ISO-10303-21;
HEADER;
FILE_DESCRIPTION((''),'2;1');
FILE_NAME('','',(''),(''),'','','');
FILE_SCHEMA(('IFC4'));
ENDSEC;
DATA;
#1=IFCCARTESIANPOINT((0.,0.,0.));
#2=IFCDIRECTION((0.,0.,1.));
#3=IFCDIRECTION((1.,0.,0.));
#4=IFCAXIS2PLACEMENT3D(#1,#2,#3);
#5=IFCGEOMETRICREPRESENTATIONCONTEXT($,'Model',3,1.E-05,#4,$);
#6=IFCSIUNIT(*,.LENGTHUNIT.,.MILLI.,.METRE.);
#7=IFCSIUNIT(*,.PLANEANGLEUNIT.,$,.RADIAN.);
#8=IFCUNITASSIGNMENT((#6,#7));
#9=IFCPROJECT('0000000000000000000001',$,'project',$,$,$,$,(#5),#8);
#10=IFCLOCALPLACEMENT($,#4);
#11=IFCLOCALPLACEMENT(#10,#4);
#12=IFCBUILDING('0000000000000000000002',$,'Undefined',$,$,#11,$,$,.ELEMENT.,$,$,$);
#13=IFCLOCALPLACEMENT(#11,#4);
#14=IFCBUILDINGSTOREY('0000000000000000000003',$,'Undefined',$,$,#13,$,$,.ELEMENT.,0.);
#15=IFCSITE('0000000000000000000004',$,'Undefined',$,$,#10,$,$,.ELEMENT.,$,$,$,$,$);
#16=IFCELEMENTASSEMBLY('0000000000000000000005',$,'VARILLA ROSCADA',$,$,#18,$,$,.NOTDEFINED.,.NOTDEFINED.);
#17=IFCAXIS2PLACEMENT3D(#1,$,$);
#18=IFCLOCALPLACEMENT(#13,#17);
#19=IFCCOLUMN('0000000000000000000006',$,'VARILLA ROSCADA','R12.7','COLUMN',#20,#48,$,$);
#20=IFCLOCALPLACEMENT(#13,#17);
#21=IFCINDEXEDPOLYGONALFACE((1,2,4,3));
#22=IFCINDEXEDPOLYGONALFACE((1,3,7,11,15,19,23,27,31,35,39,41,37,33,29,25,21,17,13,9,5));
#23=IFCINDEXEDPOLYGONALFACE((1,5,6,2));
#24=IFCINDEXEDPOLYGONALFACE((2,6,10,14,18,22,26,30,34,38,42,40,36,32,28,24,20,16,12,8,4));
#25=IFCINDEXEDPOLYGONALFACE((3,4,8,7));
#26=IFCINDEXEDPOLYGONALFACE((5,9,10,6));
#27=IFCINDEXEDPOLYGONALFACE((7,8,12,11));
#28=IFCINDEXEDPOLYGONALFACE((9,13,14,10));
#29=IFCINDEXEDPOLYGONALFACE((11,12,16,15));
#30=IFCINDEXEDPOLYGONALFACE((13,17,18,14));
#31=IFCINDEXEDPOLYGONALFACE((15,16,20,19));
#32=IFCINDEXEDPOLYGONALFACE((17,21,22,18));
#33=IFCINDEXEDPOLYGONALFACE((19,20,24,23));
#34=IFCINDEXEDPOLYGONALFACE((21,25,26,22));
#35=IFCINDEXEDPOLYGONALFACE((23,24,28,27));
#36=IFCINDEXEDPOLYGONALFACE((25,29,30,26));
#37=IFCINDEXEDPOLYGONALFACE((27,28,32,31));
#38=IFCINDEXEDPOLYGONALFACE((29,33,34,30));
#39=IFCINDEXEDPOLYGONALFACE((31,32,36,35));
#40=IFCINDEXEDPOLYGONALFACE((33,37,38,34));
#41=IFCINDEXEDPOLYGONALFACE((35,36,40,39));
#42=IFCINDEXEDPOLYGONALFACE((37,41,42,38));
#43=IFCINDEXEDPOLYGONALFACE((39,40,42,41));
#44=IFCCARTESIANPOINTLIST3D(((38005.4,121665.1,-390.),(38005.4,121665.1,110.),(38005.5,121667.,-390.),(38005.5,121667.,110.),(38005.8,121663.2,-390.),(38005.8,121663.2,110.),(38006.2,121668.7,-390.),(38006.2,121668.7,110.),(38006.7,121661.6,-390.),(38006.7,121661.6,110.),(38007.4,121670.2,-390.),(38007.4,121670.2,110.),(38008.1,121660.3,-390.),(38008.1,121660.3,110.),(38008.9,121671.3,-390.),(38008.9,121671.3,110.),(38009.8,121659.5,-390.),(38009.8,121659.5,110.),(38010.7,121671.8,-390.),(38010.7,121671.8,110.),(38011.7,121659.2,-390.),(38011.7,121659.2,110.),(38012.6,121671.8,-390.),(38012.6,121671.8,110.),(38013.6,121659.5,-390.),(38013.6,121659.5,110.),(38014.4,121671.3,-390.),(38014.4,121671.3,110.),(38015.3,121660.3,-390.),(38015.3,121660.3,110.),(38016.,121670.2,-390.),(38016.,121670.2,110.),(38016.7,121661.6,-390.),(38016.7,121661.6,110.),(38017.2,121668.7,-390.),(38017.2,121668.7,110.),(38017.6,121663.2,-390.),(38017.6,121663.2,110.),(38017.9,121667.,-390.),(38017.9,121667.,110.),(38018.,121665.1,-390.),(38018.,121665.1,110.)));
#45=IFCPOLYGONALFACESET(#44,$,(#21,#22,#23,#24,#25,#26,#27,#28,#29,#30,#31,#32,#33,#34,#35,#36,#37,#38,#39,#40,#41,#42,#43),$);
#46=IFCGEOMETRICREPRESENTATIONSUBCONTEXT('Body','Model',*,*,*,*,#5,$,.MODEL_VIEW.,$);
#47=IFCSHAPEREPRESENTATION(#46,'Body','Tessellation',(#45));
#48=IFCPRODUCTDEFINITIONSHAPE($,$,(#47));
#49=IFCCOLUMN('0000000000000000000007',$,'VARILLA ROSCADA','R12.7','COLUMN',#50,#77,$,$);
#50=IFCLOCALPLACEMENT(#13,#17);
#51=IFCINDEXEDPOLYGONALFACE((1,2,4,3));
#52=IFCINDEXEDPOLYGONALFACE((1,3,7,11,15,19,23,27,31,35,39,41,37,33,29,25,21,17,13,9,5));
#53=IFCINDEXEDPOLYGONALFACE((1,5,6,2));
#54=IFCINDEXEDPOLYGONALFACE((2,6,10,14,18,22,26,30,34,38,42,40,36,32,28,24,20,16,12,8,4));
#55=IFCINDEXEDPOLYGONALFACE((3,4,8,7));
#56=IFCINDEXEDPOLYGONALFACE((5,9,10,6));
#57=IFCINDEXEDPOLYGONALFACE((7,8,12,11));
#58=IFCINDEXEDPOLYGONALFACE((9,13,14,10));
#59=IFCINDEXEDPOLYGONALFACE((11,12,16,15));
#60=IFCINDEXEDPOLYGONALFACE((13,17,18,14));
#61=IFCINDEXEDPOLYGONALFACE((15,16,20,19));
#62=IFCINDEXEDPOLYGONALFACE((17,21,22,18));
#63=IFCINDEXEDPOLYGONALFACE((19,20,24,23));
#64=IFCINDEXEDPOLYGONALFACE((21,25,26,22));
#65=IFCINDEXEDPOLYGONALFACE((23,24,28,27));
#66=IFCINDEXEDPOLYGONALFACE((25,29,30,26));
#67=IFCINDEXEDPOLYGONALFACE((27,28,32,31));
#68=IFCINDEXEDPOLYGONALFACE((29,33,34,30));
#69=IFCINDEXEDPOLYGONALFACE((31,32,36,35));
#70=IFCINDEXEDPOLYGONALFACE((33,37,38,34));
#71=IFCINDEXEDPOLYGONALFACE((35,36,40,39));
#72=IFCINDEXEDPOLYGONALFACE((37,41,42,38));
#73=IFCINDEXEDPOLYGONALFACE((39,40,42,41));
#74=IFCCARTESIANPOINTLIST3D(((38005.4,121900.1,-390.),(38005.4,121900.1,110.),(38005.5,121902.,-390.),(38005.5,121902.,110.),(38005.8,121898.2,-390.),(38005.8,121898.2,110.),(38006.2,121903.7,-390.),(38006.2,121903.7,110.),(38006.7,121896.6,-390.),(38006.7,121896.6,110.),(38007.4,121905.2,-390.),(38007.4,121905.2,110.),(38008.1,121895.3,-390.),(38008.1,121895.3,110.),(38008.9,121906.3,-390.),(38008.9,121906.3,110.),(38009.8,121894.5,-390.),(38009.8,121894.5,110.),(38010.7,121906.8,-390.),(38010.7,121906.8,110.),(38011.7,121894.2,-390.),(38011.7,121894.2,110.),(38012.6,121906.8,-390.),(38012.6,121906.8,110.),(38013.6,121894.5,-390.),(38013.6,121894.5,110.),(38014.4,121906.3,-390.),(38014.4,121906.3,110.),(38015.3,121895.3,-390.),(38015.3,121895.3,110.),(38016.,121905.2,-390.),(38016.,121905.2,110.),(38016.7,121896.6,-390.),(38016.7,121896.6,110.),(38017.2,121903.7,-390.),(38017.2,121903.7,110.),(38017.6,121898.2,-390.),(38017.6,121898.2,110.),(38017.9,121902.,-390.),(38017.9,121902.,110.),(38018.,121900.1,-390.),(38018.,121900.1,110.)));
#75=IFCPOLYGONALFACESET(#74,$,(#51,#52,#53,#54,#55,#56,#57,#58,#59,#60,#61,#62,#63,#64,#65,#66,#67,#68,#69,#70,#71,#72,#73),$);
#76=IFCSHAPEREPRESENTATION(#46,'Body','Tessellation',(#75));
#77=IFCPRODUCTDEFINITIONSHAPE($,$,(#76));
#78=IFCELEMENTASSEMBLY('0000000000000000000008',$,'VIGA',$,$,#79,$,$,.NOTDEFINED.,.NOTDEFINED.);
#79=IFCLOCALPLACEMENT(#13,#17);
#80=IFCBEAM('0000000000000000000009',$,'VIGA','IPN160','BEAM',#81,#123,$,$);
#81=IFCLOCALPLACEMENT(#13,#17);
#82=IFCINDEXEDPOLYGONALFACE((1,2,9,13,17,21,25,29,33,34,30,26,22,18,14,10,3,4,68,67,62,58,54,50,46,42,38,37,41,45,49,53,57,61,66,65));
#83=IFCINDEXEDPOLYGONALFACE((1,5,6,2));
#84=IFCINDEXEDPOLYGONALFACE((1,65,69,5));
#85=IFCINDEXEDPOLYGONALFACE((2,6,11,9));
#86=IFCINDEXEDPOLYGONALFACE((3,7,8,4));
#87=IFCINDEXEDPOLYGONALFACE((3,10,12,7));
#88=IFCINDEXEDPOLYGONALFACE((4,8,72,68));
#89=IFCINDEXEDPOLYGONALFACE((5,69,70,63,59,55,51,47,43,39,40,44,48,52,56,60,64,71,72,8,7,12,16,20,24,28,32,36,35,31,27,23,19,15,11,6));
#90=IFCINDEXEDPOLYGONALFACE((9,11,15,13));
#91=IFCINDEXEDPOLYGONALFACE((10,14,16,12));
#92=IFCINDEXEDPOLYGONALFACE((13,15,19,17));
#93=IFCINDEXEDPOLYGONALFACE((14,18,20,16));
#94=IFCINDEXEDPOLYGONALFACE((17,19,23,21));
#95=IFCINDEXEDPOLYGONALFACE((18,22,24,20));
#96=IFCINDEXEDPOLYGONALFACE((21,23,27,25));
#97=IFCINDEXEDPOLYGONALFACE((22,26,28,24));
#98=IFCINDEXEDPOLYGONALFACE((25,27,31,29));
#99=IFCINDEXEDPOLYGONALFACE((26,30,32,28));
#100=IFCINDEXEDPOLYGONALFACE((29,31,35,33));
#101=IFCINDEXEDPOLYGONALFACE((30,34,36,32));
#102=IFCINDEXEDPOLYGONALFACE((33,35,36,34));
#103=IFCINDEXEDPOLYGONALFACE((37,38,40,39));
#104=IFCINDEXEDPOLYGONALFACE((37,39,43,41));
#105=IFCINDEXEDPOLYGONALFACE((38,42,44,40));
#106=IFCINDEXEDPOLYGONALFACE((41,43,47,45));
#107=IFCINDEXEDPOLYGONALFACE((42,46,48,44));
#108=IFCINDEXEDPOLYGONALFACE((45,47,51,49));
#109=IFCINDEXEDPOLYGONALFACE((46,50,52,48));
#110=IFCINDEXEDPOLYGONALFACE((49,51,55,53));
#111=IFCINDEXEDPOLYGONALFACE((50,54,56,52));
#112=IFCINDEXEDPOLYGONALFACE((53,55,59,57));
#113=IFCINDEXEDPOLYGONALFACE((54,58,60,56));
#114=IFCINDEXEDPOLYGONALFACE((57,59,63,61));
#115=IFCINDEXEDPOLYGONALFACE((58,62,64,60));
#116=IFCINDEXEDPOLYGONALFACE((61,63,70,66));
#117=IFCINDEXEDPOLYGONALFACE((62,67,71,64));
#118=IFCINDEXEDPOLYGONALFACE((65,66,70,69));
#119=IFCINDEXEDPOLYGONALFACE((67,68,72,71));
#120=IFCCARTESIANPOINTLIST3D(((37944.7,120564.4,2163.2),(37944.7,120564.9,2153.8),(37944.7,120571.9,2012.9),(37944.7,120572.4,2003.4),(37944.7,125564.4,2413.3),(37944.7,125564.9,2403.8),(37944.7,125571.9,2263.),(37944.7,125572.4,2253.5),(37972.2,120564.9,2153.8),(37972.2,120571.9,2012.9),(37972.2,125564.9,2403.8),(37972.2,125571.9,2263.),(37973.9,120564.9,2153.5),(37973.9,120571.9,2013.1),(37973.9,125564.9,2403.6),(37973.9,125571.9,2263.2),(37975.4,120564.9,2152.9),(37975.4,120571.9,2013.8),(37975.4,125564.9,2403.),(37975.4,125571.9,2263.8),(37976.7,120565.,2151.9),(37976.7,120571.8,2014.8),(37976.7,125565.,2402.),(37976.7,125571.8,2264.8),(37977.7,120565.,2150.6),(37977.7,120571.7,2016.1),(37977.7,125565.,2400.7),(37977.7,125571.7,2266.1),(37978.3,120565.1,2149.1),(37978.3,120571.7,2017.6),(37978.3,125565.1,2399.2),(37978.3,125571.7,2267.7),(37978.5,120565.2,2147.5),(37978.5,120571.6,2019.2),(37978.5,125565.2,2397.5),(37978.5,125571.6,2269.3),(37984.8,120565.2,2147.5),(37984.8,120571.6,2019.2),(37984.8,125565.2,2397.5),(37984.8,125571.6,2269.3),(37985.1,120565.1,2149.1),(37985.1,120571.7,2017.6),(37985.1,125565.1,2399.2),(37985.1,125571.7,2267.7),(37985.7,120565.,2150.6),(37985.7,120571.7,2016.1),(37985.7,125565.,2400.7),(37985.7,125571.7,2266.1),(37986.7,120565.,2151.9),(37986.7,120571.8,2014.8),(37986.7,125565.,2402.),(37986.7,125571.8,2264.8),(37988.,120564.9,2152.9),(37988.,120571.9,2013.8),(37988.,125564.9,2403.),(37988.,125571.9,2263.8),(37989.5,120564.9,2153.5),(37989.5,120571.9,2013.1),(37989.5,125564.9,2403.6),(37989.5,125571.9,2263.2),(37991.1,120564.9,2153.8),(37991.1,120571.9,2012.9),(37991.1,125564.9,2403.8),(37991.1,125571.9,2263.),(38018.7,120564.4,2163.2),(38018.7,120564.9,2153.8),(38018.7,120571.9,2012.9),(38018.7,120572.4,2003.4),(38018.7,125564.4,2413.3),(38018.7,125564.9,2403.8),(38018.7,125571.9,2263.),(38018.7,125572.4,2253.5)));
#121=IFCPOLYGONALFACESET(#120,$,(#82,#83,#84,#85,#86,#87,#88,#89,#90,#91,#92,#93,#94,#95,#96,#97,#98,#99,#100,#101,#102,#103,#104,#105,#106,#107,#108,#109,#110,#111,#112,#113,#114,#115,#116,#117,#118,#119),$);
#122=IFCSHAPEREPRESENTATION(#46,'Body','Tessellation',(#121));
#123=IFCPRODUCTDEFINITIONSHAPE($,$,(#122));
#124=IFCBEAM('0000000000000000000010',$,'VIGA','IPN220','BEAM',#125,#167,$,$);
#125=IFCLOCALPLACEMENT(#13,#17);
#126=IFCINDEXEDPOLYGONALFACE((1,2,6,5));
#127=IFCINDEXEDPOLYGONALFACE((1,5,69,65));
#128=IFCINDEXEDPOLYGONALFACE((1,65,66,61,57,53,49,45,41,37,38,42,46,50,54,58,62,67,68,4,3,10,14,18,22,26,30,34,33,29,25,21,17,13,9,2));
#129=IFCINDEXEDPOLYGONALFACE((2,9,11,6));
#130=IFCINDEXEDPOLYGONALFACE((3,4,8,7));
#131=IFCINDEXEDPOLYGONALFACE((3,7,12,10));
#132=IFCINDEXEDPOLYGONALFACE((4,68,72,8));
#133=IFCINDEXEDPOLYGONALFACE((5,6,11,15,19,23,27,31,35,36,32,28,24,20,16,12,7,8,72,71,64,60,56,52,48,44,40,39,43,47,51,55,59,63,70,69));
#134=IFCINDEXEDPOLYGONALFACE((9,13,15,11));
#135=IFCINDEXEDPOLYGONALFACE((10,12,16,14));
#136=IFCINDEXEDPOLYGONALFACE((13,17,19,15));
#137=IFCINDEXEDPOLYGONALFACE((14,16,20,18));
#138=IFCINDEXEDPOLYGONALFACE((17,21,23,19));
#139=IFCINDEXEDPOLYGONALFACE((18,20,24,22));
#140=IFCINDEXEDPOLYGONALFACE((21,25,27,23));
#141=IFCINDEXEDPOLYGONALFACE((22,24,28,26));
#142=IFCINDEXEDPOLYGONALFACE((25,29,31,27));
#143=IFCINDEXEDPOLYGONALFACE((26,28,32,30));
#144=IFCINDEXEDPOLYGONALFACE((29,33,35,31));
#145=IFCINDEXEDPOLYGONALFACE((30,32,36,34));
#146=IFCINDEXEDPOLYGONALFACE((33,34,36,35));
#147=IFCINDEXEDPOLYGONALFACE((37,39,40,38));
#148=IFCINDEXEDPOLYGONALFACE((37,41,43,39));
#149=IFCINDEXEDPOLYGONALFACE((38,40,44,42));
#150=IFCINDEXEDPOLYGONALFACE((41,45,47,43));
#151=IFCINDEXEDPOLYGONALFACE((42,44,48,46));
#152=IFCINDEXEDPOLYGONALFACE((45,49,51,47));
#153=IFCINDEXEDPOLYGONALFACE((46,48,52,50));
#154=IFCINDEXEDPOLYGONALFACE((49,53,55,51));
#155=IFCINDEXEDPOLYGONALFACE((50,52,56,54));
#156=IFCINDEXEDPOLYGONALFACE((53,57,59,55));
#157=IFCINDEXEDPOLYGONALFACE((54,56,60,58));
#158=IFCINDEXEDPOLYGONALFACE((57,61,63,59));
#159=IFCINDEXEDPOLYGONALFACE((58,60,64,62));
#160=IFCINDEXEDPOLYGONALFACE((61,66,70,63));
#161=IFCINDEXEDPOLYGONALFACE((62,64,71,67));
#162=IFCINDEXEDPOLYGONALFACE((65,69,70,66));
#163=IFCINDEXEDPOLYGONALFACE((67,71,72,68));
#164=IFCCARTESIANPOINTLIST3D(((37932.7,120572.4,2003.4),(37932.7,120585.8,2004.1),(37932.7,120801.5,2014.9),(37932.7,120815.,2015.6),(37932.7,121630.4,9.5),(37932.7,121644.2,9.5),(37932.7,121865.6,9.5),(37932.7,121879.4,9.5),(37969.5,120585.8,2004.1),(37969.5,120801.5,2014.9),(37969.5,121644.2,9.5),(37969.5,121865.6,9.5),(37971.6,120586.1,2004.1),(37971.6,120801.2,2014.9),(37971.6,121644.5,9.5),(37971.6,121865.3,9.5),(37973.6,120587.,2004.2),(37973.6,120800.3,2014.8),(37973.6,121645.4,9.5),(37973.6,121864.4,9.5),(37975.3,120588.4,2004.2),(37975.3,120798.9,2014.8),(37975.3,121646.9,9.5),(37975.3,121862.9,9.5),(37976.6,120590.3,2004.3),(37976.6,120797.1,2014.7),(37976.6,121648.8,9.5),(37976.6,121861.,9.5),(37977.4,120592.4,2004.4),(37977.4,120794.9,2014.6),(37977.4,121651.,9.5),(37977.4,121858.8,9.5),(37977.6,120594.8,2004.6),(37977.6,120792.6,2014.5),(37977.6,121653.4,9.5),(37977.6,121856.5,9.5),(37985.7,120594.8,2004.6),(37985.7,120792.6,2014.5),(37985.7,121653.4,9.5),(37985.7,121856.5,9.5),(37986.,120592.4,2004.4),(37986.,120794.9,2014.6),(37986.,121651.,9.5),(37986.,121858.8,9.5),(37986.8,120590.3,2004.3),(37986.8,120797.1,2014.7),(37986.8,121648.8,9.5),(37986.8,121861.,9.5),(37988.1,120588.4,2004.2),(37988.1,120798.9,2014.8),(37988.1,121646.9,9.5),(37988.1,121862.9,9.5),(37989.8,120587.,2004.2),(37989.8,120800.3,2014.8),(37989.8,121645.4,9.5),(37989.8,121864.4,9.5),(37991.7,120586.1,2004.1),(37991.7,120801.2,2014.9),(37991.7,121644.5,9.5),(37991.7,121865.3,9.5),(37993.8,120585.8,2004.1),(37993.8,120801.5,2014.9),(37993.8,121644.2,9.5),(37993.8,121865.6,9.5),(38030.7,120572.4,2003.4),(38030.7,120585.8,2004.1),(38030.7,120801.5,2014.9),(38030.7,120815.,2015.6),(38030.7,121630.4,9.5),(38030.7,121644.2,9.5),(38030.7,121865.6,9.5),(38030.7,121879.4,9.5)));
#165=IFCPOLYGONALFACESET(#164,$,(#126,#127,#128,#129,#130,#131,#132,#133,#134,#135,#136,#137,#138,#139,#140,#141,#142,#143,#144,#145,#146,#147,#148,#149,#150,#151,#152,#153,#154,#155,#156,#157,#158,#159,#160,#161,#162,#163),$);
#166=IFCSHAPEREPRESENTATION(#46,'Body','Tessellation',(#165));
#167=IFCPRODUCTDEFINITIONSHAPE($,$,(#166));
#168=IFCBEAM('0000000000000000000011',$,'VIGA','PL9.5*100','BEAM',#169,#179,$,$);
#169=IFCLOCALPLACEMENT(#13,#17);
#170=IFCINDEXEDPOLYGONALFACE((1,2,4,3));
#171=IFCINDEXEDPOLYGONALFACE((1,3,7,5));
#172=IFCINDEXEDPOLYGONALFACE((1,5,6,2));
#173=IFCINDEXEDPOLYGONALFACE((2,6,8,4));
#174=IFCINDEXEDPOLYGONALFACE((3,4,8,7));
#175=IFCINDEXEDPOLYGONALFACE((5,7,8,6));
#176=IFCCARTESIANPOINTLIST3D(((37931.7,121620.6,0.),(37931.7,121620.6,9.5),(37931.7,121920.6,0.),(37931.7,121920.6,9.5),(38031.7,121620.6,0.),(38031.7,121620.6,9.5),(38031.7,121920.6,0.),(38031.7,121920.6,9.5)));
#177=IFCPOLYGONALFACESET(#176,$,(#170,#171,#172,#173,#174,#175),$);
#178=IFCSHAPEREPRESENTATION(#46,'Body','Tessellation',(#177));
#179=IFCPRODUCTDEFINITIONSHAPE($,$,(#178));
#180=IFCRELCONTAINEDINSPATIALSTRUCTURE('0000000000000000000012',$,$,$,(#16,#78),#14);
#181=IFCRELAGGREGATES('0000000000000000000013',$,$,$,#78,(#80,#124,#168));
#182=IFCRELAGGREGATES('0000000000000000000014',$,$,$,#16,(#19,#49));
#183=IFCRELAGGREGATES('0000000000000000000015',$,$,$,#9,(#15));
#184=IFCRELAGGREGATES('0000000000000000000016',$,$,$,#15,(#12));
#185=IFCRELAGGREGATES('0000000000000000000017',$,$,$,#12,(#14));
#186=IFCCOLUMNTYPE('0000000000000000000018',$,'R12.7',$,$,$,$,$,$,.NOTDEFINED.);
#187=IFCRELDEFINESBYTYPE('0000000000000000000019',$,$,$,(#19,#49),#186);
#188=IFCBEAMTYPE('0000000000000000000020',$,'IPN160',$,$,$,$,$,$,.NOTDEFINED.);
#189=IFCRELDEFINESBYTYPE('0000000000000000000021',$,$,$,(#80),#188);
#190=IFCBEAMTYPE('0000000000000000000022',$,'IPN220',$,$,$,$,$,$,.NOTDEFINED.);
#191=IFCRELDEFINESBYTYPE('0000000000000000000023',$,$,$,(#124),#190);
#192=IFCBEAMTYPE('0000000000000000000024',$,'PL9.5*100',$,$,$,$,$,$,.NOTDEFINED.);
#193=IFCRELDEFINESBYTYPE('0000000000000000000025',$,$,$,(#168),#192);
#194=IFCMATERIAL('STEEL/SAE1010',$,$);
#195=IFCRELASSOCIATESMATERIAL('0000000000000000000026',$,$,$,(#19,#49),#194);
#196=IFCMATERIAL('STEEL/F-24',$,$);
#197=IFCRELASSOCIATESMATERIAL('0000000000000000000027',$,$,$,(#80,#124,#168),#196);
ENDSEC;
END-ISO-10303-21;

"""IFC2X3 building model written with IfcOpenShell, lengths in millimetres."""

from ifc_helpers import new_model, si_unit, frame, origin_with_axes, origin_2d_with_axis, place, context, subcontext, project, spatial, rectangle, circle, i_section, extrude, clip, halfspace, material, type_object, element, aggregate, save


model = new_model("IFC2X3")

# Units and contexts
model_context = context("Model", 3, precision=1e-05, world=origin_with_axes())
body_context = subcontext(model_context, "Body", "Model", "MODEL_VIEW")
ifc_project = project(units=[si_unit("LENGTHUNIT", "METRE", prefix="MILLI"), si_unit("PLANEANGLEUNIT", "RADIAN")], contexts=[model_context])

# Site, building, storey
site_placement = place(None, origin_with_axes())
site = spatial("IfcSite", under=ifc_project, at=site_placement, Name="Undefined", CompositionType="ELEMENT")
building_placement = place(site_placement, origin_with_axes())
building = spatial("IfcBuilding", under=site, at=building_placement, Name="Undefined", CompositionType="ELEMENT")
storey_placement = place(building_placement, origin_with_axes())
storey = spatial("IfcBuildingStorey", under=building, at=storey_placement, Name="Undefined", CompositionType="ELEMENT", Elevation=0.0)

# Element assembly, columns
assembly_1_placement = place(storey_placement, origin_with_axes())
assembly_1 = element("IfcElementAssembly", 1, at=assembly_1_placement, inside=storey, Name="VARILLA ROSCADA", AssemblyPlace="NOTDEFINED", PredefinedType="NOTDEFINED")
ifc_material_1 = material(Name="STEEL/SAE1010")
column_type = type_object("IfcColumnType", Name="R12.7", PredefinedType="NOTDEFINED")
column_1_placement = place(assembly_1_placement, frame((38011.7, 121665.6, -390.0), z_axis=(0.0, 0.0, 1.0), x_axis=(-1.0, 0.0, 0.0)))
column_1 = element("IfcColumn", 2, at=column_1_placement, type_object=column_type, material=ifc_material_1, Name="VARILLA ROSCADA", Description="R12.7", ObjectType="COLUMN", context=body_context, shape_type="SweptSolid", body=[
    extrude(circle(Radius=6.3, at=origin_2d_with_axis()), frame((0.0, 0.0, 500.0), z_axis=(0.0, 0.0, -1.0), x_axis=(0.0, 1.0, 0.0)), (0.0, 0.0, 1.0), 500.0),
])
column_2_placement = place(assembly_1_placement, frame((38011.7, 121900.6, -390.0), z_axis=(0.0, 0.0, 1.0), x_axis=(-1.0, 0.0, 0.0)))
column_2 = element("IfcColumn", 3, at=column_2_placement, type_object=column_type, material=ifc_material_1, Name="VARILLA ROSCADA", Description="R12.7", ObjectType="COLUMN", context=body_context, shape_type="SweptSolid", body=[
    extrude(circle(Radius=6.3, at=origin_2d_with_axis()), frame((0.0, 0.0, 500.0), z_axis=(0.0, 0.0, -1.0), x_axis=(0.0, 1.0, 0.0)), (0.0, 0.0, 1.0), 500.0),
])

# Element assembly, beams
assembly_2_placement = place(storey_placement, origin_with_axes())
assembly_2 = element("IfcElementAssembly", 4, at=assembly_2_placement, inside=storey, Name="VIGA", AssemblyPlace="NOTDEFINED", PredefinedType="NOTDEFINED")
ifc_material_2 = material(Name="STEEL/F-24")
beam_type_1 = type_object("IfcBeamType", Name="IPN160", PredefinedType="NOTDEFINED")
beam_1_placement = place(assembly_2_placement, frame((37981.7, 120568.4, 2083.3), z_axis=(0.0, -0.04995, 0.998752), x_axis=(0.0, 0.998752, 0.04995)))
beam_1 = element("IfcBeam", 5, at=beam_1_placement, type_object=beam_type_1, material=ifc_material_2, Name="VIGA", Description="IPN160", ObjectType="BEAM", context=body_context, shape_type="SweptSolid", body=[
    extrude(i_section(OverallWidth=74.0, OverallDepth=160.0, WebThickness=6.3, FlangeThickness=9.5, FilletRadius=6.3, at=origin_2d_with_axis()), frame((5006.2, 0.0, 0.0), z_axis=(-1.0, 0.0, 0.0), x_axis=(0.0, -1.0, 0.0)), (0.0, 0.0, 1.0), 5006.2),
])
beam_type_2 = type_object("IfcBeamType", Name="IPN220", PredefinedType="NOTDEFINED")
beam_2_placement = place(assembly_2_placement, frame((37981.7, 121754.9, 9.5), z_axis=(0.0, -0.88335, -0.468715), x_axis=(0.0, -0.468715, 0.88335)))
beam_2 = element("IfcBeam", 6, at=beam_2_placement, type_object=beam_type_2, material=ifc_material_2, Name="VIGA", Description="IPN220", ObjectType="BEAM", context=body_context, shape_type="Clipping", body=[
    clip(clip(extrude(i_section(OverallWidth=98.0, OverallDepth=220.0, WebThickness=8.1, FlangeThickness=12.2, FilletRadius=8.1, at=origin_2d_with_axis()), frame((2385.9, 0.0, 0.0), z_axis=(-1.0, 0.0, 0.0), x_axis=(0.0, -1.0, 0.0)), (0.0, 0.0, 1.0), 2507.7), halfspace(frame((2264.1, 0.0, 0.0), z_axis=(-0.905659, 0.0, 0.424006), x_axis=(0.0, 1.0, 0.0)), True)), halfspace(frame((0.0, 0.0, 0.0), z_axis=(-0.88335, 0.0, 0.468715), x_axis=(0.0, -1.0, 0.0)), False)),
])
beam_type_3 = type_object("IfcBeamType", Name="PL9.5*100", PredefinedType="NOTDEFINED")
beam_3_placement = place(assembly_2_placement, frame((37981.7, 121620.6, 4.7), z_axis=(1.0, 0.0, 0.0), x_axis=(0.0, 1.0, 0.0)))
beam_3 = element("IfcBeam", 7, at=beam_3_placement, type_object=beam_type_3, material=ifc_material_2, Name="VIGA", Description="PL9.5*100", ObjectType="BEAM", context=body_context, shape_type="SweptSolid", body=[
    extrude(rectangle(XDim=9.5, YDim=100.0, at=origin_2d_with_axis()), frame((300.0, 0.0, 0.0), z_axis=(-1.0, 0.0, 0.0), x_axis=(0.0, -1.0, 0.0)), (0.0, 0.0, 1.0), 300.0),
])

aggregate(assembly_2, [beam_1, beam_2, beam_3])

aggregate(assembly_1, [column_1, column_2])

save(model, "model.ifc")
